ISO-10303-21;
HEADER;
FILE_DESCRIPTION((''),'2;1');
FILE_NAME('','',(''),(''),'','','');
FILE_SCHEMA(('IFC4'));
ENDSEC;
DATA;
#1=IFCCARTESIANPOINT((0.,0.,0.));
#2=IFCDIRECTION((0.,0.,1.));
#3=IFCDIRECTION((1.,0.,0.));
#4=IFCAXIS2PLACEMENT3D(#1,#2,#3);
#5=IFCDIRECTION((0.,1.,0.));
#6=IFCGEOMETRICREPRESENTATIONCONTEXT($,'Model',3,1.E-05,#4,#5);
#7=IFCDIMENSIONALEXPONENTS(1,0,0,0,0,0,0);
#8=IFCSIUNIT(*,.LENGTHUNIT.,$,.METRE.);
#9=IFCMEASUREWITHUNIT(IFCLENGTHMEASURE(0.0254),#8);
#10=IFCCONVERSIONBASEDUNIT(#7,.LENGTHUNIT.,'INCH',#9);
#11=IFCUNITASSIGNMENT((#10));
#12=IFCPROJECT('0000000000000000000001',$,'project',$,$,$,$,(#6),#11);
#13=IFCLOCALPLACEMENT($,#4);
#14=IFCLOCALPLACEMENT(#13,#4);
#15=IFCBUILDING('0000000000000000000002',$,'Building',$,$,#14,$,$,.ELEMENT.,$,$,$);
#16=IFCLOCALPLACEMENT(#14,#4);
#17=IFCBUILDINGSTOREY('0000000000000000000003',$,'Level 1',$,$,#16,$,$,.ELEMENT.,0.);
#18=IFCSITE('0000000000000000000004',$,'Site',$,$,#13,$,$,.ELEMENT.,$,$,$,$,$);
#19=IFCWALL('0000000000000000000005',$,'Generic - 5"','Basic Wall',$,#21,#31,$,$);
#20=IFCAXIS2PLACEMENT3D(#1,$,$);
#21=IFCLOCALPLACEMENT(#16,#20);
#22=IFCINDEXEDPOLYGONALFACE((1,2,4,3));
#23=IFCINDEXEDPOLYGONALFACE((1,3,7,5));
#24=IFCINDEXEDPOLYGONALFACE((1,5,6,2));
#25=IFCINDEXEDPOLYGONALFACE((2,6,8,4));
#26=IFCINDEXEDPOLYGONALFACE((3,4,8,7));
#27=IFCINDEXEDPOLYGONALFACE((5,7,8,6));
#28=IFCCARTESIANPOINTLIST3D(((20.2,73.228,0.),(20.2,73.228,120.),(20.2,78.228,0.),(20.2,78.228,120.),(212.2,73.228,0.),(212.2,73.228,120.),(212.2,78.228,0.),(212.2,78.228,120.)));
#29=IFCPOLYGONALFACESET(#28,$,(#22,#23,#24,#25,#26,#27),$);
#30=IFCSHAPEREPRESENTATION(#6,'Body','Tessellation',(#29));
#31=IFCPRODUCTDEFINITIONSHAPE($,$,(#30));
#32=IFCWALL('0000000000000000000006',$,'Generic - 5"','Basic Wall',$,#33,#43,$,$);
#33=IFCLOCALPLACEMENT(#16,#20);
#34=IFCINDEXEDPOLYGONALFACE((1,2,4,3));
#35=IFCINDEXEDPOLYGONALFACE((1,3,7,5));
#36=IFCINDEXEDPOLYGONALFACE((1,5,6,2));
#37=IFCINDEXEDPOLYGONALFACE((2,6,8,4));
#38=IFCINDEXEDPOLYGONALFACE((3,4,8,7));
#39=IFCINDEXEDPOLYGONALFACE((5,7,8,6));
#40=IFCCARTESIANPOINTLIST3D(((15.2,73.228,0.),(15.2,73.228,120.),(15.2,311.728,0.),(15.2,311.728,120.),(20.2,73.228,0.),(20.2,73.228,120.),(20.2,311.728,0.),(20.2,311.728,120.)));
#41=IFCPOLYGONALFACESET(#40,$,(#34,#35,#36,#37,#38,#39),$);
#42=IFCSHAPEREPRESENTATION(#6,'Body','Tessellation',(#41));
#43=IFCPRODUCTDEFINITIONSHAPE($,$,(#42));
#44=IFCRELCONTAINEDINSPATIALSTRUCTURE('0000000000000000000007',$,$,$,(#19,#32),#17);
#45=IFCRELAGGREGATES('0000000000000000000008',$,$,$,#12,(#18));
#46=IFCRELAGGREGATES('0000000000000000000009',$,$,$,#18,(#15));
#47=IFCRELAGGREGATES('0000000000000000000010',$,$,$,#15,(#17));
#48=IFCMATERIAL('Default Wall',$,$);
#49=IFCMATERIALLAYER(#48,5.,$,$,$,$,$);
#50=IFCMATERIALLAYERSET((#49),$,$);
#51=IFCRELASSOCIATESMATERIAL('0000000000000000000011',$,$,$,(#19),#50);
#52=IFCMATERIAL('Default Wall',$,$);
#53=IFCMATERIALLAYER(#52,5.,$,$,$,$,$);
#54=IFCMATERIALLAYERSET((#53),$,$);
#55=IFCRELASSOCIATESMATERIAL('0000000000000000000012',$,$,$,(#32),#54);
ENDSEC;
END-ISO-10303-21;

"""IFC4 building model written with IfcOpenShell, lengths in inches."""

from ifc_helpers import new_model, entity, si_unit, converted_unit, direction, origin_with_axes, place, context, project, spatial, polyline, outline, extrude, material, layer, layer_set, layer_usage, element, save


model = new_model("IFC4")

# Units and contexts
model_context = context("Model", 3, precision=1e-05, world=origin_with_axes(), true_north=direction((0.0, 1.0, 0.0)))
ifc_project = project(units=[converted_unit("LENGTHUNIT", "INCH", entity("IfcLengthMeasure", 0.0254), si_unit("LENGTHUNIT", "METRE"), dimensions=[1, 0, 0, 0, 0, 0, 0])], contexts=[model_context])

# Site, building, storey
site_placement = place(None, origin_with_axes())
site = spatial("IfcSite", under=ifc_project, at=site_placement, Name="Site", CompositionType="ELEMENT")
building_placement = place(site_placement, origin_with_axes())
building = spatial("IfcBuilding", under=site, at=building_placement, Name="Building", CompositionType="ELEMENT")
storey_placement = place(building_placement, origin_with_axes())
storey = spatial("IfcBuildingStorey", under=building, at=storey_placement, Name="Level 1", CompositionType="ELEMENT", Elevation=0.0)

# Walls
ifc_material_1 = material(Name="Default Wall")
ifc_layer_1 = layer(ifc_material_1, 5.0)
ifc_layer_set_1 = layer_set([ifc_layer_1])
ifc_layer_usage_1 = layer_usage(ifc_layer_set_1, "AXIS2", "NEGATIVE", 2.5)
wall_1_placement = place(storey_placement, origin_with_axes())
element("IfcWall", 1, at=wall_1_placement, inside=storey, material=ifc_layer_usage_1, Name="Generic - 5\"", Description="Basic Wall", context=model_context, shape_type="SweptSolid", body=[
    extrude(outline(polyline([(20.2, 73.228, 0.0), (20.2, 78.228, 0.0), (212.2, 78.228, 0.0), (212.2, 73.228, 0.0), (20.2, 73.228, 0.0)])), origin_with_axes(), (0.0, 0.0, 1.0), 120.0),
])
ifc_material_2 = material(Name="Default Wall")
ifc_layer_2 = layer(ifc_material_2, 5.0)
ifc_layer_set_2 = layer_set([ifc_layer_2])
ifc_layer_usage_2 = layer_usage(ifc_layer_set_2, "AXIS2", "NEGATIVE", 2.5)
wall_2_placement = place(storey_placement, origin_with_axes())
element("IfcWall", 2, at=wall_2_placement, inside=storey, material=ifc_layer_usage_2, Name="Generic - 5\"", Description="Basic Wall", context=model_context, shape_type="SweptSolid", body=[
    extrude(outline(polyline([(15.2, 73.228, 0.0), (15.2, 311.728, 0.0), (20.2, 311.728, 0.0), (20.2, 73.228, 0.0), (15.2, 73.228, 0.0)])), origin_with_axes(), (0.0, 0.0, 1.0), 120.0),
])

save(model, "model.ifc")
